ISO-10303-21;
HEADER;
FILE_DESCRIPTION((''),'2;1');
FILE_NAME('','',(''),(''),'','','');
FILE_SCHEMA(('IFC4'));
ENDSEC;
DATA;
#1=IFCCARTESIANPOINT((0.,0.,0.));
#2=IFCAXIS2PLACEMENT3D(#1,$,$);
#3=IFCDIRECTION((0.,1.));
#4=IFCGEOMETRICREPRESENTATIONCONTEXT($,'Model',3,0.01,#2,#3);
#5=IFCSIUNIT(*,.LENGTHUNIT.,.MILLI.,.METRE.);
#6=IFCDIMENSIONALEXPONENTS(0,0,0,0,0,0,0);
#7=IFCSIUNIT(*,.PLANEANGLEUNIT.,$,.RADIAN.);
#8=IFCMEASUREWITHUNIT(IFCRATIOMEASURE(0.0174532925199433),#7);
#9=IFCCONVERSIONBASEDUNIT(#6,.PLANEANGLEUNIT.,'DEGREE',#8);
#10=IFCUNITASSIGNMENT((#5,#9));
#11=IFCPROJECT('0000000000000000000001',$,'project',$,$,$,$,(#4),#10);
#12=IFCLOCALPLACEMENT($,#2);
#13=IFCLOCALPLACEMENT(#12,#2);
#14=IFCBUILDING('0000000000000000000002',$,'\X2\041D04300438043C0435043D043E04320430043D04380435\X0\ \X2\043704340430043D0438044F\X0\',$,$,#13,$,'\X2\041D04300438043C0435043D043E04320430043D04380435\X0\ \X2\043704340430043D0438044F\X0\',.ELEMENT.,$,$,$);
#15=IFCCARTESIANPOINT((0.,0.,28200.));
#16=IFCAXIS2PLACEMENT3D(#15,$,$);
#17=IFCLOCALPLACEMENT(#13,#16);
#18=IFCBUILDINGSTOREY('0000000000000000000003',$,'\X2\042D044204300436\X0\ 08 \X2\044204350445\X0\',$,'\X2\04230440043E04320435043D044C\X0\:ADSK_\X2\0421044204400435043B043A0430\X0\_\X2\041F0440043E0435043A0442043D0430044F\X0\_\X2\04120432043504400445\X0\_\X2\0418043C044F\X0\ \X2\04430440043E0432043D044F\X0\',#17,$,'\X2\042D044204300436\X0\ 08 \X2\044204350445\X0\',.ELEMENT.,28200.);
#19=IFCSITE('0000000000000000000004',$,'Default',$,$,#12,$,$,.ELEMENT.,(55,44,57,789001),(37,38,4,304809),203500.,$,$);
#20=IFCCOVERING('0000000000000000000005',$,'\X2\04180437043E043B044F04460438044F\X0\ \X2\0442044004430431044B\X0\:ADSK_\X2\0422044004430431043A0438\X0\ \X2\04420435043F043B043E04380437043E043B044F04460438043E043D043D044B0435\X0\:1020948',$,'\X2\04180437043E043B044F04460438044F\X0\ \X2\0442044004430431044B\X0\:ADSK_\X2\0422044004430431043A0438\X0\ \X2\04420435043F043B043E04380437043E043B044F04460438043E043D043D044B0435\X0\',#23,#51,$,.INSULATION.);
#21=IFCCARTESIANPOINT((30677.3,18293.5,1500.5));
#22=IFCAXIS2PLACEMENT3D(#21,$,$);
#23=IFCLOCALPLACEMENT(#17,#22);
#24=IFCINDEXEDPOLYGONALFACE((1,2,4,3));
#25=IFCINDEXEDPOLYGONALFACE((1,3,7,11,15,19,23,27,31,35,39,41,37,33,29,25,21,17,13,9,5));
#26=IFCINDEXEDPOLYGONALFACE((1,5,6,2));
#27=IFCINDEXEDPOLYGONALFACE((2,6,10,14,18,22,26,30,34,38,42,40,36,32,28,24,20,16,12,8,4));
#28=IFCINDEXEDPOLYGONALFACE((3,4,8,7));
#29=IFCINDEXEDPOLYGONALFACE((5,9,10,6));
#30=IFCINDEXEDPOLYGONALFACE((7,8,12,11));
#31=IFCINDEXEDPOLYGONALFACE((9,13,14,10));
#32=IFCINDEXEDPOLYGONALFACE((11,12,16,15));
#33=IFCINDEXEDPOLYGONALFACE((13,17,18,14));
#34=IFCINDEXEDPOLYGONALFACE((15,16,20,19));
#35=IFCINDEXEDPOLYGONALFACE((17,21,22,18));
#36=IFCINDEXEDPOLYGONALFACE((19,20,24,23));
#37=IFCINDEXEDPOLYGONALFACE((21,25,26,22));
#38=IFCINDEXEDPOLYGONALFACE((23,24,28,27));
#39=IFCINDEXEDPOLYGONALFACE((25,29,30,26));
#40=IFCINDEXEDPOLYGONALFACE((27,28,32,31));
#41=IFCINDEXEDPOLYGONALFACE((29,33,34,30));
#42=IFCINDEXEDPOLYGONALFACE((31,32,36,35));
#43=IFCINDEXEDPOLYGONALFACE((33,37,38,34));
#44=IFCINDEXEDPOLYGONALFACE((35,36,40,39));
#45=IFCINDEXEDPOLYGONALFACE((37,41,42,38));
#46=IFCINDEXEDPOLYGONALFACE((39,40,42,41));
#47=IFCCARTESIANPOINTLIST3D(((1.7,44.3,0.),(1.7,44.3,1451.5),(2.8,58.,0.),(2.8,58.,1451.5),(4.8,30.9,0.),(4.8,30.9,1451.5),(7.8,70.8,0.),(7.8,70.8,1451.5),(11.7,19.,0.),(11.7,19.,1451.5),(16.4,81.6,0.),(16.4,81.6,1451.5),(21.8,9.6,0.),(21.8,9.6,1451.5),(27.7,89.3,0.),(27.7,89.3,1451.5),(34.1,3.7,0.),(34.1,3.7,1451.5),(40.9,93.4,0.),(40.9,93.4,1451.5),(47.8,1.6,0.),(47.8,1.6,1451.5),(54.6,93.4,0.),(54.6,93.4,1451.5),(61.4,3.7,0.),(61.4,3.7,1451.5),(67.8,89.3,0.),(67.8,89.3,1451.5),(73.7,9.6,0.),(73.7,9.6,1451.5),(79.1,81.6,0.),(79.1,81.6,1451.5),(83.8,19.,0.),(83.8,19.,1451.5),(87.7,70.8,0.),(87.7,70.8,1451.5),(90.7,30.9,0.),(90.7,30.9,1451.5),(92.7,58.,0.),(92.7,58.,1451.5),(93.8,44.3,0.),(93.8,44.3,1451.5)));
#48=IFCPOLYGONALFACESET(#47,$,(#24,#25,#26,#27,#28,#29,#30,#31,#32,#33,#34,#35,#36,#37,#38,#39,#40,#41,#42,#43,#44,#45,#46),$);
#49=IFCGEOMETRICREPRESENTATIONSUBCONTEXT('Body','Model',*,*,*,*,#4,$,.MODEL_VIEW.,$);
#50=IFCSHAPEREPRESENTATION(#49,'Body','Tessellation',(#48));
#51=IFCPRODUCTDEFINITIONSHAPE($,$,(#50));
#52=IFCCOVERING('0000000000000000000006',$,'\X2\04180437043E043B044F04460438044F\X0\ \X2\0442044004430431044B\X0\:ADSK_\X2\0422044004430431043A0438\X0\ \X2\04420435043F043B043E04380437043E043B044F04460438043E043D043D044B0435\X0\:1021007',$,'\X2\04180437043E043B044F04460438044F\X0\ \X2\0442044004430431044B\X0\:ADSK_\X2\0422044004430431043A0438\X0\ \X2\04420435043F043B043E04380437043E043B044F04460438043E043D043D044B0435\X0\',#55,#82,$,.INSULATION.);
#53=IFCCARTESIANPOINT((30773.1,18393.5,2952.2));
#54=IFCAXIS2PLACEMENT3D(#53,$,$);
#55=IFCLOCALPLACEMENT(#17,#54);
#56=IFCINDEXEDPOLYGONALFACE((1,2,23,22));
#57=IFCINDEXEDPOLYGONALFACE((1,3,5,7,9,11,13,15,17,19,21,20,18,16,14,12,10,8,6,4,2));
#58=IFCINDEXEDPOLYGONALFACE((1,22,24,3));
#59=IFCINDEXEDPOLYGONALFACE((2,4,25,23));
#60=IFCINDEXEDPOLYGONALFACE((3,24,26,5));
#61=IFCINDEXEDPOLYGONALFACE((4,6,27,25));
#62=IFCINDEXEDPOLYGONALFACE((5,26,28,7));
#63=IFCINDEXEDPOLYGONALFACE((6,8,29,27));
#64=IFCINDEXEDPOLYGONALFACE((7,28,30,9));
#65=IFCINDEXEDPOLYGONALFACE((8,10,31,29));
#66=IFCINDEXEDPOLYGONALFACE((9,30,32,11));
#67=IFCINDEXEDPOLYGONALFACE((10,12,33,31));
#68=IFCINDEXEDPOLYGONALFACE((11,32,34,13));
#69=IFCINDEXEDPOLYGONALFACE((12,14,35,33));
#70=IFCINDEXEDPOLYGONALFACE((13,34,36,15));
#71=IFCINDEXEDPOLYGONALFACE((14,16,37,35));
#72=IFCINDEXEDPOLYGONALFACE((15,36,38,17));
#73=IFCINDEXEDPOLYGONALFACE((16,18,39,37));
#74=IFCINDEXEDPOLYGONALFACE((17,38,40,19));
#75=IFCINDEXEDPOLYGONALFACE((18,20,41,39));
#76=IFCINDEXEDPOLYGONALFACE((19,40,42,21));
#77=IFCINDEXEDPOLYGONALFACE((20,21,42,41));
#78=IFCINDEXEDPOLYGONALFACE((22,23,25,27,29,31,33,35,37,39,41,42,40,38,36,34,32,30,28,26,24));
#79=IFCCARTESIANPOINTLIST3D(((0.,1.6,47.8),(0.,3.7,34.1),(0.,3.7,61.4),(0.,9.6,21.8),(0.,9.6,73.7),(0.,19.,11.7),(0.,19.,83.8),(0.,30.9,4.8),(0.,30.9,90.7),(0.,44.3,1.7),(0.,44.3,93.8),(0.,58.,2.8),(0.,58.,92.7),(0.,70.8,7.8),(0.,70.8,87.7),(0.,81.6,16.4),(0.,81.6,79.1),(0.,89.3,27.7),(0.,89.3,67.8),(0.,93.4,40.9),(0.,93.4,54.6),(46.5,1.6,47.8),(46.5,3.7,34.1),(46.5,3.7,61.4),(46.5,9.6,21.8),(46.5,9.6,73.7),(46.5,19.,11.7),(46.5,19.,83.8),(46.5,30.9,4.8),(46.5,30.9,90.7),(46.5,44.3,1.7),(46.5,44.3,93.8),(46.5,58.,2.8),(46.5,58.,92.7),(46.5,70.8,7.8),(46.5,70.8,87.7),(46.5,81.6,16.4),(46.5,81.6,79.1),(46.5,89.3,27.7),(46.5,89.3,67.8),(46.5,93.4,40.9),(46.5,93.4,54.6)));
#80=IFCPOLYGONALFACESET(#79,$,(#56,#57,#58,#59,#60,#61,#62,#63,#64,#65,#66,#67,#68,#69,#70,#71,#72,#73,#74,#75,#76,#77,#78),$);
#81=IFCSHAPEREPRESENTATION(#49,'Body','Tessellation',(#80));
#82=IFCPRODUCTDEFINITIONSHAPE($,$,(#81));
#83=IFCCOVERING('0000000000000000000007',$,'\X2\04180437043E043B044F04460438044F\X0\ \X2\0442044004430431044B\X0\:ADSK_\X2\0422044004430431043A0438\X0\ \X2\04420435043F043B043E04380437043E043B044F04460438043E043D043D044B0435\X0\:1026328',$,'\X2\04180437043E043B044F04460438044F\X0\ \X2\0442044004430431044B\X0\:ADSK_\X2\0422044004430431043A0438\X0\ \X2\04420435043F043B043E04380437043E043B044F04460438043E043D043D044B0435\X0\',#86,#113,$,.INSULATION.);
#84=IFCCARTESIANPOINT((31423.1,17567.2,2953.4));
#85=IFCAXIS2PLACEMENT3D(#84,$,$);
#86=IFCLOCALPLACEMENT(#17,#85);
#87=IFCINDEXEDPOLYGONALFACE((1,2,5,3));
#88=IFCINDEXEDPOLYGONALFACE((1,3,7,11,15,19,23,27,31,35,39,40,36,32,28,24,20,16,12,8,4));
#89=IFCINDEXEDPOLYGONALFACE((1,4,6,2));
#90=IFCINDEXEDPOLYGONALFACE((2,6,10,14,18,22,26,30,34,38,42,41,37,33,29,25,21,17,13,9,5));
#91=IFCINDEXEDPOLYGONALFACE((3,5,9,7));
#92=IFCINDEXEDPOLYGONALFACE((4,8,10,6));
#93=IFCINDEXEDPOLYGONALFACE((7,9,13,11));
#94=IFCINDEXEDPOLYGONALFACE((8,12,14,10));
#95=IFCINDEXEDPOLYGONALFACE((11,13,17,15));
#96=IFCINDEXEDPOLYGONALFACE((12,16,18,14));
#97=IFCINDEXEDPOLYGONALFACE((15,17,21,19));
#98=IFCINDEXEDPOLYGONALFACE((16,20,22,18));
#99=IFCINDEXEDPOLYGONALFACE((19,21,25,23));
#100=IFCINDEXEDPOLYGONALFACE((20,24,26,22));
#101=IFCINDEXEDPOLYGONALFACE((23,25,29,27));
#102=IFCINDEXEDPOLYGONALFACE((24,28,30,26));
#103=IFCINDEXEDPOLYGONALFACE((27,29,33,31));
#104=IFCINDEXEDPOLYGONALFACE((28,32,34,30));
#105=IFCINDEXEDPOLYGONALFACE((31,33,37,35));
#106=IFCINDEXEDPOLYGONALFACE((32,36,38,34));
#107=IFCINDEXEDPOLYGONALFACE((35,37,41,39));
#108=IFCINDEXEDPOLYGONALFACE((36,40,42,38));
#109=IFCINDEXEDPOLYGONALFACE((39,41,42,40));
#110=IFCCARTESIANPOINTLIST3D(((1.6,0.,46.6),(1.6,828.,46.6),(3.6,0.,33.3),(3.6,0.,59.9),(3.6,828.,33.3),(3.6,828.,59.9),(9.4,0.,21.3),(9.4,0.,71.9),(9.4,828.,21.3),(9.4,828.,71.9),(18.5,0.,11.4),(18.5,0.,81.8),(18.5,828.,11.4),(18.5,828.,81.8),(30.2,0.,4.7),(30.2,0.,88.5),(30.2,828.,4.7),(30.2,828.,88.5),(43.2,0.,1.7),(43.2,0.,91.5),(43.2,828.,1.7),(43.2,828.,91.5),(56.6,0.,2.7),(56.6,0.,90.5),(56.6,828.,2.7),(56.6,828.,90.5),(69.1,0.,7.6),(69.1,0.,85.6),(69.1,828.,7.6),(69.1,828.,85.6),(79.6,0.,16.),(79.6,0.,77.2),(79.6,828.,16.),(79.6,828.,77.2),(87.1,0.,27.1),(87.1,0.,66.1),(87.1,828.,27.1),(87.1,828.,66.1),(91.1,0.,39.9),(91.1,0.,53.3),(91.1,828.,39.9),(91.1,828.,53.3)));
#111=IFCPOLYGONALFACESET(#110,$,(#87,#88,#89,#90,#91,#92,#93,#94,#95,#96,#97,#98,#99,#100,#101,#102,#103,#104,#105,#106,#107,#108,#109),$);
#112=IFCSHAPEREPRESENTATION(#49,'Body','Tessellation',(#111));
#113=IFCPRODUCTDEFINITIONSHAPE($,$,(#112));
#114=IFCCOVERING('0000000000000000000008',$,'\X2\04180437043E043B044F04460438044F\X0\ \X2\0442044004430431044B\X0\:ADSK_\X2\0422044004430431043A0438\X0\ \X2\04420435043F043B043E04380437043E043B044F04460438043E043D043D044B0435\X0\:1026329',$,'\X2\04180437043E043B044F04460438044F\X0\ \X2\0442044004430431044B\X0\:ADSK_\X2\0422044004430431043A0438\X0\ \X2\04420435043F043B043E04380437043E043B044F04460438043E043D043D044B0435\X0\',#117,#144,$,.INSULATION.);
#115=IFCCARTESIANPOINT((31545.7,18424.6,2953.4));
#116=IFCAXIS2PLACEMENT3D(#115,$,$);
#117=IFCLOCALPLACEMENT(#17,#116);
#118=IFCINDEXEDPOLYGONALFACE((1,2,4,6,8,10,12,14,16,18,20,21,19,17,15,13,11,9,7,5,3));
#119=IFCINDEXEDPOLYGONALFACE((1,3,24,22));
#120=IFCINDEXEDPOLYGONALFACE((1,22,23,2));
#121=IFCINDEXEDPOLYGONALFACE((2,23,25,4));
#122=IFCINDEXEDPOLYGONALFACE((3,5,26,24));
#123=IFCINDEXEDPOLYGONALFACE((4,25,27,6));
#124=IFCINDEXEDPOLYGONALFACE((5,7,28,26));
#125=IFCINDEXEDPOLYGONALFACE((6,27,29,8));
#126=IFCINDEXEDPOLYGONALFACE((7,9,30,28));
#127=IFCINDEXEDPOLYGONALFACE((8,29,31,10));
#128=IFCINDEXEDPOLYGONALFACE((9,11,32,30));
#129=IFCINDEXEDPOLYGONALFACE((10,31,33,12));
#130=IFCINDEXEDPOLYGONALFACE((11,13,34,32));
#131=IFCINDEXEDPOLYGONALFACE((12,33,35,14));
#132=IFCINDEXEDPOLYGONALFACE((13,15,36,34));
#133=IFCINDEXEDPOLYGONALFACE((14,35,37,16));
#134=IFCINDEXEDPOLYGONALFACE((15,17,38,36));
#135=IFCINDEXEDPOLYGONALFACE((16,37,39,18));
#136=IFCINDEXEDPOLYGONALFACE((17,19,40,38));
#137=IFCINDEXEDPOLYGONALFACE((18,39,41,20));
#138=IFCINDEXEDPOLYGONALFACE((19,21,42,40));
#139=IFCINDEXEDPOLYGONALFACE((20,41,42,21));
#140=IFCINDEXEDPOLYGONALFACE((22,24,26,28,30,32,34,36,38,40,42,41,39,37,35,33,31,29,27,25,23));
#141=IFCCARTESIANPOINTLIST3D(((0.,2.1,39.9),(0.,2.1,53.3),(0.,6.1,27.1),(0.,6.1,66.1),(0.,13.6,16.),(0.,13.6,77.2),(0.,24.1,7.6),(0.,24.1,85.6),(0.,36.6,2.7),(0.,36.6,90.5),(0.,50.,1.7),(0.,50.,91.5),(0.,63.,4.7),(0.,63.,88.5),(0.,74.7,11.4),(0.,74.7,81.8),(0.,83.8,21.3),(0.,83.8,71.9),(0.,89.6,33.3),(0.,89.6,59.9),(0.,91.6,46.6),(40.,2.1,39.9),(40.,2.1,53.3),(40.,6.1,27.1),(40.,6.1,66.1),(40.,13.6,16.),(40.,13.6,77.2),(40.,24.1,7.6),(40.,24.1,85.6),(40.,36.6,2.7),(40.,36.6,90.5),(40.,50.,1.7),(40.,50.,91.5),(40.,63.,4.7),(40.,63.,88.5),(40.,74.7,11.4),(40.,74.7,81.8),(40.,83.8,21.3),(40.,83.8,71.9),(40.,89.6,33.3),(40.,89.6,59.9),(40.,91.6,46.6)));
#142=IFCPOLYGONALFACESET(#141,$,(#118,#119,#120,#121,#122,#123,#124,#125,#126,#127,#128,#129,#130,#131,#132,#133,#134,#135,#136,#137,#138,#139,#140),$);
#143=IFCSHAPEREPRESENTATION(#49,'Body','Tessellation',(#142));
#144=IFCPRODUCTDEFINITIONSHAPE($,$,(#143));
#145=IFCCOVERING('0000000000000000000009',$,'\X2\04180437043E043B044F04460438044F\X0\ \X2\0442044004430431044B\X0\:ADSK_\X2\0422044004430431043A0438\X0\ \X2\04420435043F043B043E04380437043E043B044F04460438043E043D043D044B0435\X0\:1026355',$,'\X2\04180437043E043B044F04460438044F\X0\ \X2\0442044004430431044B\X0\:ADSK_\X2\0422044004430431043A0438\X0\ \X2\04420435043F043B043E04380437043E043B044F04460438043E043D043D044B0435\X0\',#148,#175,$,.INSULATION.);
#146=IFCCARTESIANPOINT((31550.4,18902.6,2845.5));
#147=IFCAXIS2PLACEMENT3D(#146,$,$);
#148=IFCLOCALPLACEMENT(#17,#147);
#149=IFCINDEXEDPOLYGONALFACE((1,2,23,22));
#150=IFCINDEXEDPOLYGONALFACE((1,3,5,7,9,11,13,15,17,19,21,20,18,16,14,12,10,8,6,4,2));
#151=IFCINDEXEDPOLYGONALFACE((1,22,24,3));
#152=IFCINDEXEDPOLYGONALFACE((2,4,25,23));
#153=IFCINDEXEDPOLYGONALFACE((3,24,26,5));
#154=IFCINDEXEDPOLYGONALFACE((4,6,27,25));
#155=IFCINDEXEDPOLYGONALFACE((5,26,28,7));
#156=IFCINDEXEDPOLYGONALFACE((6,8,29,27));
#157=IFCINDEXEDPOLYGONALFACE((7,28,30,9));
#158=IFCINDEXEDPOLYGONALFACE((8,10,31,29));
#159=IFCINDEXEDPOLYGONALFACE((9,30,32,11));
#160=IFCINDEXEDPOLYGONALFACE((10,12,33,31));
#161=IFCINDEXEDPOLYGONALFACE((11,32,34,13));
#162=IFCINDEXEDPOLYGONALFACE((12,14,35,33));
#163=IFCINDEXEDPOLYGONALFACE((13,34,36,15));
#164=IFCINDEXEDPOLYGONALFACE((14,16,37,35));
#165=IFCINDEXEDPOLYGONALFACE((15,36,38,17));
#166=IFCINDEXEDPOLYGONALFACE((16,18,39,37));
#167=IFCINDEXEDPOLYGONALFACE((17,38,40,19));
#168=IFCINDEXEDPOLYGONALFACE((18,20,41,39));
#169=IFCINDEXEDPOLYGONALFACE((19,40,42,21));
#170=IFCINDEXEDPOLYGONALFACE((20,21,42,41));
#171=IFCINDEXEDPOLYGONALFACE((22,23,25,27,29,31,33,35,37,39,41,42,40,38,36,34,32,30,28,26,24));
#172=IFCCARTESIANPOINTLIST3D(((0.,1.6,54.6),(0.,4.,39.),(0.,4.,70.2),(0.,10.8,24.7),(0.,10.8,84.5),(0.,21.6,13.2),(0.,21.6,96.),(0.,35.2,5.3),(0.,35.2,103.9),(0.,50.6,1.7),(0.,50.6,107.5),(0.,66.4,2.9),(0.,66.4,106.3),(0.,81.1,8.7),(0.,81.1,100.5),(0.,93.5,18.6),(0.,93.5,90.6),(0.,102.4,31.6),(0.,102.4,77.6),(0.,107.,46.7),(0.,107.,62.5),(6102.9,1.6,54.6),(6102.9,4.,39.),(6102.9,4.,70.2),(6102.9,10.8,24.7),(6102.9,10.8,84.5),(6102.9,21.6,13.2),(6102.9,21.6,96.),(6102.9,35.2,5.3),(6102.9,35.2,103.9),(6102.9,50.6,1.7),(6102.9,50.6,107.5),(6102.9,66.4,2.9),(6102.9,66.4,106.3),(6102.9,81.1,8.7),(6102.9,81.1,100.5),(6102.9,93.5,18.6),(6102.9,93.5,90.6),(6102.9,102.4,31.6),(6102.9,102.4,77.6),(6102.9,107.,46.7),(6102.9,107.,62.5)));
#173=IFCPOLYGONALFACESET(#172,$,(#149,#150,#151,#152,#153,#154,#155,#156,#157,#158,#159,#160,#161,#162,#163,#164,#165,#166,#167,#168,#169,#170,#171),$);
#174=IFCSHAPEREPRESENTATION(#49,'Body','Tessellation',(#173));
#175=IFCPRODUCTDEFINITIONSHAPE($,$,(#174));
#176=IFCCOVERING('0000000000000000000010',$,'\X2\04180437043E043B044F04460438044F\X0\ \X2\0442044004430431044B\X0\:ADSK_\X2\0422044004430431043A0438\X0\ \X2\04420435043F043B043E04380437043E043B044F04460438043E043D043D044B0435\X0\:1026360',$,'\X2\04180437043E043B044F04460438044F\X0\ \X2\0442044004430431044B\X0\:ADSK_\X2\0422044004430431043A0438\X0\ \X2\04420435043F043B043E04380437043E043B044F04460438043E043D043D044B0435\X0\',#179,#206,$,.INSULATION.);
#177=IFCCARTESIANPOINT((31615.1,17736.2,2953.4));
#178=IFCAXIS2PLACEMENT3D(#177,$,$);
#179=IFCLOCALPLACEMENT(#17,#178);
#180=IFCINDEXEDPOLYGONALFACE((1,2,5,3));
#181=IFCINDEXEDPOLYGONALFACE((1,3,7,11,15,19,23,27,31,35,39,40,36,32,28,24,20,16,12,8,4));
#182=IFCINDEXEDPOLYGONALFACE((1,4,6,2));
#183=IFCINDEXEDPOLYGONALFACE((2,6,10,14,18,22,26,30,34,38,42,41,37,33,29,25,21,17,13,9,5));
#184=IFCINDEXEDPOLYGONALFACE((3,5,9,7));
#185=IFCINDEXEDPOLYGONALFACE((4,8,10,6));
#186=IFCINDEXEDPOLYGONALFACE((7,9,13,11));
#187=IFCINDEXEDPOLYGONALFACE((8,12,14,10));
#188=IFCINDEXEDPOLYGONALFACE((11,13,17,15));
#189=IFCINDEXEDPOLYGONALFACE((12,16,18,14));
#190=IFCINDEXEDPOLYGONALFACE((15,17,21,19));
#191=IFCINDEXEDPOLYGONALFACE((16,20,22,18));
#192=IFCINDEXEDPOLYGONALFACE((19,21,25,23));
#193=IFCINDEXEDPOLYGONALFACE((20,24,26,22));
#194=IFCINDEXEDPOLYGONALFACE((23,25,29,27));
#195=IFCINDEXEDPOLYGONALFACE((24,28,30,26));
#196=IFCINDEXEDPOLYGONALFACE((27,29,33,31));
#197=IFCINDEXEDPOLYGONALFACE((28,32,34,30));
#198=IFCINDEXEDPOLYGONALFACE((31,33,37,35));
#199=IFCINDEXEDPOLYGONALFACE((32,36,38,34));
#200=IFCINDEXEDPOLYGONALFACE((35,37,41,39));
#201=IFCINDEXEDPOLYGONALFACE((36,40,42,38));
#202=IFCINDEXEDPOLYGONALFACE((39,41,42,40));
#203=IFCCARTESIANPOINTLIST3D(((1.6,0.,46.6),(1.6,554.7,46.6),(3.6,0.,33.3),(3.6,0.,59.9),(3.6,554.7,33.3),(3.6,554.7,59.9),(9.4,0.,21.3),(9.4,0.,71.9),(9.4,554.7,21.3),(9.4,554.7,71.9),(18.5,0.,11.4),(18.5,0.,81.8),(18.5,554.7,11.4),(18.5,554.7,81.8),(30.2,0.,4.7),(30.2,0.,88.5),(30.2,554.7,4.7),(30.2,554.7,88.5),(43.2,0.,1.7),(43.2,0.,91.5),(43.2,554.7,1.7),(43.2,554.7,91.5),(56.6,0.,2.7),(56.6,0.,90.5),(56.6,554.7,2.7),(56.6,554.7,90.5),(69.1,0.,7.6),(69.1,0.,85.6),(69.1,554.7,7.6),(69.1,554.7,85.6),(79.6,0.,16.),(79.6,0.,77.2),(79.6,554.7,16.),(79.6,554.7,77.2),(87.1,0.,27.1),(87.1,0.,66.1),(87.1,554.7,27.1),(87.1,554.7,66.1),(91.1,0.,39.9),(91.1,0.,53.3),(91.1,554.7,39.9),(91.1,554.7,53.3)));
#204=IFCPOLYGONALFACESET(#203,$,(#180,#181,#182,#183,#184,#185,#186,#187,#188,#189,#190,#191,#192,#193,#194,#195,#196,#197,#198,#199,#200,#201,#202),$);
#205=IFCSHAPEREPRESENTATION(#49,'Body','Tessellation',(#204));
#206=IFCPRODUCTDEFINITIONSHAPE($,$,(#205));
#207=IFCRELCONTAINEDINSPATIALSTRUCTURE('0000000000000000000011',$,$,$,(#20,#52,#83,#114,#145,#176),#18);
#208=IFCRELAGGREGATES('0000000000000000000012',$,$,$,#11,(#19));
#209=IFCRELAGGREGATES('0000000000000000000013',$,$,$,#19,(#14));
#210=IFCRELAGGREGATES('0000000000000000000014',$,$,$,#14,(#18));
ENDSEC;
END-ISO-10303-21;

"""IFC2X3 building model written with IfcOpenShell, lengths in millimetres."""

from ifc_helpers import new_model, entity, si_unit, converted_unit, direction, frame, origin, origin_2d_with_axis, place, context, subcontext, project, spatial, circle, extrude, element, save


model = new_model("IFC2X3")

# Units and contexts
model_context = context("Model", 3, precision=0.01, world=origin(), true_north=direction((0.0, 1.0)))
body_context = subcontext(model_context, "Body", "Model", "MODEL_VIEW")
ifc_project = project(units=[si_unit("LENGTHUNIT", "METRE", prefix="MILLI"), converted_unit("PLANEANGLEUNIT", "DEGREE", entity("IfcRatioMeasure", 0.0174532925199433), si_unit("PLANEANGLEUNIT", "RADIAN"), dimensions=[0, 0, 0, 0, 0, 0, 0])], contexts=[model_context])

# Site, building, storey
site_placement = place(None, origin())
site = spatial("IfcSite", under=ifc_project, at=site_placement, Name="Default", CompositionType="ELEMENT", RefLatitude=(55, 44, 57, 789001), RefLongitude=(37, 38, 4, 304809), RefElevation=203500.0)
building_placement = place(site_placement, origin())
building = spatial("IfcBuilding", under=site, at=building_placement, Name="Наименование здания", LongName="Наименование здания", CompositionType="ELEMENT")
storey_placement = place(building_placement, frame((0.0, 0.0, 28200.0)))
storey = spatial("IfcBuildingStorey", under=building, at=storey_placement, Name="Этаж 08 тех", ObjectType="Уровень:ADSK_Стрелка_Проектная_Вверх_Имя уровня", LongName="Этаж 08 тех", CompositionType="ELEMENT", Elevation=28200.0)

# Coverings
covering_1_placement = place(storey_placement, frame((30677.3, 18293.5, 1500.5)))
element("IfcCovering", 1, at=covering_1_placement, inside=storey, Name="Изоляция трубы:ADSK_Трубки теплоизоляционные:1020948", ObjectType="Изоляция трубы:ADSK_Трубки теплоизоляционные", PredefinedType="INSULATION", context=body_context, shape_type="SweptSolid", body=[
    extrude(circle(Radius=46.1, at=origin_2d_with_axis()), frame((47.8, 47.8, 0.0), z_axis=(0.0, 0.0, 1.0), x_axis=(0.0, -1.0, 0.0)), (0.0, 0.0, 1.0), 1451.5),
])
covering_2_placement = place(storey_placement, frame((30773.1, 18393.5, 2952.2)))
element("IfcCovering", 2, at=covering_2_placement, inside=storey, Name="Изоляция трубы:ADSK_Трубки теплоизоляционные:1021007", ObjectType="Изоляция трубы:ADSK_Трубки теплоизоляционные", PredefinedType="INSULATION", context=body_context, shape_type="SweptSolid", body=[
    extrude(circle(Radius=46.1, at=origin_2d_with_axis()), frame((0.0, 47.8, 47.8), z_axis=(1.0, 0.0, 0.0), x_axis=(0.0, -1.0, 0.0)), (0.0, 0.0, 1.0), 46.5),
])
covering_3_placement = place(storey_placement, frame((31423.1, 17567.2, 2953.4)))
element("IfcCovering", 3, at=covering_3_placement, inside=storey, Name="Изоляция трубы:ADSK_Трубки теплоизоляционные:1026328", ObjectType="Изоляция трубы:ADSK_Трубки теплоизоляционные", PredefinedType="INSULATION", context=body_context, shape_type="SweptSolid", body=[
    extrude(circle(Radius=45.0, at=origin_2d_with_axis()), frame((46.6, 0.0, 46.6), z_axis=(0.0, 1.0, 0.0), x_axis=(-1.0, 0.0, 0.0)), (0.0, 0.0, 1.0), 828.0),
])
covering_4_placement = place(storey_placement, frame((31545.7, 18424.6, 2953.4)))
element("IfcCovering", 4, at=covering_4_placement, inside=storey, Name="Изоляция трубы:ADSK_Трубки теплоизоляционные:1026329", ObjectType="Изоляция трубы:ADSK_Трубки теплоизоляционные", PredefinedType="INSULATION", context=body_context, shape_type="SweptSolid", body=[
    extrude(circle(Radius=45.0, at=origin_2d_with_axis()), frame((0.0, 46.6, 46.6), z_axis=(1.0, 0.0, 0.0), x_axis=(0.0, 1.0, 0.0)), (0.0, 0.0, 1.0), 40.0),
])
covering_5_placement = place(storey_placement, frame((31550.4, 18902.6, 2845.5)))
element("IfcCovering", 5, at=covering_5_placement, inside=storey, Name="Изоляция трубы:ADSK_Трубки теплоизоляционные:1026355", ObjectType="Изоляция трубы:ADSK_Трубки теплоизоляционные", PredefinedType="INSULATION", context=body_context, shape_type="SweptSolid", body=[
    extrude(circle(Radius=53.0, at=origin_2d_with_axis()), frame((0.0, 54.6, 54.6), z_axis=(1.0, 0.0, 0.0), x_axis=(0.0, -1.0, 0.0)), (0.0, 0.0, 1.0), 6102.9),
])
covering_6_placement = place(storey_placement, frame((31615.1, 17736.2, 2953.4)))
element("IfcCovering", 6, at=covering_6_placement, inside=storey, Name="Изоляция трубы:ADSK_Трубки теплоизоляционные:1026360", ObjectType="Изоляция трубы:ADSK_Трубки теплоизоляционные", PredefinedType="INSULATION", context=body_context, shape_type="SweptSolid", body=[
    extrude(circle(Radius=45.0, at=origin_2d_with_axis()), frame((46.6, 0.0, 46.6), z_axis=(0.0, 1.0, 0.0), x_axis=(-1.0, 0.0, 0.0)), (0.0, 0.0, 1.0), 554.7),
])

save(model, "model.ifc")
